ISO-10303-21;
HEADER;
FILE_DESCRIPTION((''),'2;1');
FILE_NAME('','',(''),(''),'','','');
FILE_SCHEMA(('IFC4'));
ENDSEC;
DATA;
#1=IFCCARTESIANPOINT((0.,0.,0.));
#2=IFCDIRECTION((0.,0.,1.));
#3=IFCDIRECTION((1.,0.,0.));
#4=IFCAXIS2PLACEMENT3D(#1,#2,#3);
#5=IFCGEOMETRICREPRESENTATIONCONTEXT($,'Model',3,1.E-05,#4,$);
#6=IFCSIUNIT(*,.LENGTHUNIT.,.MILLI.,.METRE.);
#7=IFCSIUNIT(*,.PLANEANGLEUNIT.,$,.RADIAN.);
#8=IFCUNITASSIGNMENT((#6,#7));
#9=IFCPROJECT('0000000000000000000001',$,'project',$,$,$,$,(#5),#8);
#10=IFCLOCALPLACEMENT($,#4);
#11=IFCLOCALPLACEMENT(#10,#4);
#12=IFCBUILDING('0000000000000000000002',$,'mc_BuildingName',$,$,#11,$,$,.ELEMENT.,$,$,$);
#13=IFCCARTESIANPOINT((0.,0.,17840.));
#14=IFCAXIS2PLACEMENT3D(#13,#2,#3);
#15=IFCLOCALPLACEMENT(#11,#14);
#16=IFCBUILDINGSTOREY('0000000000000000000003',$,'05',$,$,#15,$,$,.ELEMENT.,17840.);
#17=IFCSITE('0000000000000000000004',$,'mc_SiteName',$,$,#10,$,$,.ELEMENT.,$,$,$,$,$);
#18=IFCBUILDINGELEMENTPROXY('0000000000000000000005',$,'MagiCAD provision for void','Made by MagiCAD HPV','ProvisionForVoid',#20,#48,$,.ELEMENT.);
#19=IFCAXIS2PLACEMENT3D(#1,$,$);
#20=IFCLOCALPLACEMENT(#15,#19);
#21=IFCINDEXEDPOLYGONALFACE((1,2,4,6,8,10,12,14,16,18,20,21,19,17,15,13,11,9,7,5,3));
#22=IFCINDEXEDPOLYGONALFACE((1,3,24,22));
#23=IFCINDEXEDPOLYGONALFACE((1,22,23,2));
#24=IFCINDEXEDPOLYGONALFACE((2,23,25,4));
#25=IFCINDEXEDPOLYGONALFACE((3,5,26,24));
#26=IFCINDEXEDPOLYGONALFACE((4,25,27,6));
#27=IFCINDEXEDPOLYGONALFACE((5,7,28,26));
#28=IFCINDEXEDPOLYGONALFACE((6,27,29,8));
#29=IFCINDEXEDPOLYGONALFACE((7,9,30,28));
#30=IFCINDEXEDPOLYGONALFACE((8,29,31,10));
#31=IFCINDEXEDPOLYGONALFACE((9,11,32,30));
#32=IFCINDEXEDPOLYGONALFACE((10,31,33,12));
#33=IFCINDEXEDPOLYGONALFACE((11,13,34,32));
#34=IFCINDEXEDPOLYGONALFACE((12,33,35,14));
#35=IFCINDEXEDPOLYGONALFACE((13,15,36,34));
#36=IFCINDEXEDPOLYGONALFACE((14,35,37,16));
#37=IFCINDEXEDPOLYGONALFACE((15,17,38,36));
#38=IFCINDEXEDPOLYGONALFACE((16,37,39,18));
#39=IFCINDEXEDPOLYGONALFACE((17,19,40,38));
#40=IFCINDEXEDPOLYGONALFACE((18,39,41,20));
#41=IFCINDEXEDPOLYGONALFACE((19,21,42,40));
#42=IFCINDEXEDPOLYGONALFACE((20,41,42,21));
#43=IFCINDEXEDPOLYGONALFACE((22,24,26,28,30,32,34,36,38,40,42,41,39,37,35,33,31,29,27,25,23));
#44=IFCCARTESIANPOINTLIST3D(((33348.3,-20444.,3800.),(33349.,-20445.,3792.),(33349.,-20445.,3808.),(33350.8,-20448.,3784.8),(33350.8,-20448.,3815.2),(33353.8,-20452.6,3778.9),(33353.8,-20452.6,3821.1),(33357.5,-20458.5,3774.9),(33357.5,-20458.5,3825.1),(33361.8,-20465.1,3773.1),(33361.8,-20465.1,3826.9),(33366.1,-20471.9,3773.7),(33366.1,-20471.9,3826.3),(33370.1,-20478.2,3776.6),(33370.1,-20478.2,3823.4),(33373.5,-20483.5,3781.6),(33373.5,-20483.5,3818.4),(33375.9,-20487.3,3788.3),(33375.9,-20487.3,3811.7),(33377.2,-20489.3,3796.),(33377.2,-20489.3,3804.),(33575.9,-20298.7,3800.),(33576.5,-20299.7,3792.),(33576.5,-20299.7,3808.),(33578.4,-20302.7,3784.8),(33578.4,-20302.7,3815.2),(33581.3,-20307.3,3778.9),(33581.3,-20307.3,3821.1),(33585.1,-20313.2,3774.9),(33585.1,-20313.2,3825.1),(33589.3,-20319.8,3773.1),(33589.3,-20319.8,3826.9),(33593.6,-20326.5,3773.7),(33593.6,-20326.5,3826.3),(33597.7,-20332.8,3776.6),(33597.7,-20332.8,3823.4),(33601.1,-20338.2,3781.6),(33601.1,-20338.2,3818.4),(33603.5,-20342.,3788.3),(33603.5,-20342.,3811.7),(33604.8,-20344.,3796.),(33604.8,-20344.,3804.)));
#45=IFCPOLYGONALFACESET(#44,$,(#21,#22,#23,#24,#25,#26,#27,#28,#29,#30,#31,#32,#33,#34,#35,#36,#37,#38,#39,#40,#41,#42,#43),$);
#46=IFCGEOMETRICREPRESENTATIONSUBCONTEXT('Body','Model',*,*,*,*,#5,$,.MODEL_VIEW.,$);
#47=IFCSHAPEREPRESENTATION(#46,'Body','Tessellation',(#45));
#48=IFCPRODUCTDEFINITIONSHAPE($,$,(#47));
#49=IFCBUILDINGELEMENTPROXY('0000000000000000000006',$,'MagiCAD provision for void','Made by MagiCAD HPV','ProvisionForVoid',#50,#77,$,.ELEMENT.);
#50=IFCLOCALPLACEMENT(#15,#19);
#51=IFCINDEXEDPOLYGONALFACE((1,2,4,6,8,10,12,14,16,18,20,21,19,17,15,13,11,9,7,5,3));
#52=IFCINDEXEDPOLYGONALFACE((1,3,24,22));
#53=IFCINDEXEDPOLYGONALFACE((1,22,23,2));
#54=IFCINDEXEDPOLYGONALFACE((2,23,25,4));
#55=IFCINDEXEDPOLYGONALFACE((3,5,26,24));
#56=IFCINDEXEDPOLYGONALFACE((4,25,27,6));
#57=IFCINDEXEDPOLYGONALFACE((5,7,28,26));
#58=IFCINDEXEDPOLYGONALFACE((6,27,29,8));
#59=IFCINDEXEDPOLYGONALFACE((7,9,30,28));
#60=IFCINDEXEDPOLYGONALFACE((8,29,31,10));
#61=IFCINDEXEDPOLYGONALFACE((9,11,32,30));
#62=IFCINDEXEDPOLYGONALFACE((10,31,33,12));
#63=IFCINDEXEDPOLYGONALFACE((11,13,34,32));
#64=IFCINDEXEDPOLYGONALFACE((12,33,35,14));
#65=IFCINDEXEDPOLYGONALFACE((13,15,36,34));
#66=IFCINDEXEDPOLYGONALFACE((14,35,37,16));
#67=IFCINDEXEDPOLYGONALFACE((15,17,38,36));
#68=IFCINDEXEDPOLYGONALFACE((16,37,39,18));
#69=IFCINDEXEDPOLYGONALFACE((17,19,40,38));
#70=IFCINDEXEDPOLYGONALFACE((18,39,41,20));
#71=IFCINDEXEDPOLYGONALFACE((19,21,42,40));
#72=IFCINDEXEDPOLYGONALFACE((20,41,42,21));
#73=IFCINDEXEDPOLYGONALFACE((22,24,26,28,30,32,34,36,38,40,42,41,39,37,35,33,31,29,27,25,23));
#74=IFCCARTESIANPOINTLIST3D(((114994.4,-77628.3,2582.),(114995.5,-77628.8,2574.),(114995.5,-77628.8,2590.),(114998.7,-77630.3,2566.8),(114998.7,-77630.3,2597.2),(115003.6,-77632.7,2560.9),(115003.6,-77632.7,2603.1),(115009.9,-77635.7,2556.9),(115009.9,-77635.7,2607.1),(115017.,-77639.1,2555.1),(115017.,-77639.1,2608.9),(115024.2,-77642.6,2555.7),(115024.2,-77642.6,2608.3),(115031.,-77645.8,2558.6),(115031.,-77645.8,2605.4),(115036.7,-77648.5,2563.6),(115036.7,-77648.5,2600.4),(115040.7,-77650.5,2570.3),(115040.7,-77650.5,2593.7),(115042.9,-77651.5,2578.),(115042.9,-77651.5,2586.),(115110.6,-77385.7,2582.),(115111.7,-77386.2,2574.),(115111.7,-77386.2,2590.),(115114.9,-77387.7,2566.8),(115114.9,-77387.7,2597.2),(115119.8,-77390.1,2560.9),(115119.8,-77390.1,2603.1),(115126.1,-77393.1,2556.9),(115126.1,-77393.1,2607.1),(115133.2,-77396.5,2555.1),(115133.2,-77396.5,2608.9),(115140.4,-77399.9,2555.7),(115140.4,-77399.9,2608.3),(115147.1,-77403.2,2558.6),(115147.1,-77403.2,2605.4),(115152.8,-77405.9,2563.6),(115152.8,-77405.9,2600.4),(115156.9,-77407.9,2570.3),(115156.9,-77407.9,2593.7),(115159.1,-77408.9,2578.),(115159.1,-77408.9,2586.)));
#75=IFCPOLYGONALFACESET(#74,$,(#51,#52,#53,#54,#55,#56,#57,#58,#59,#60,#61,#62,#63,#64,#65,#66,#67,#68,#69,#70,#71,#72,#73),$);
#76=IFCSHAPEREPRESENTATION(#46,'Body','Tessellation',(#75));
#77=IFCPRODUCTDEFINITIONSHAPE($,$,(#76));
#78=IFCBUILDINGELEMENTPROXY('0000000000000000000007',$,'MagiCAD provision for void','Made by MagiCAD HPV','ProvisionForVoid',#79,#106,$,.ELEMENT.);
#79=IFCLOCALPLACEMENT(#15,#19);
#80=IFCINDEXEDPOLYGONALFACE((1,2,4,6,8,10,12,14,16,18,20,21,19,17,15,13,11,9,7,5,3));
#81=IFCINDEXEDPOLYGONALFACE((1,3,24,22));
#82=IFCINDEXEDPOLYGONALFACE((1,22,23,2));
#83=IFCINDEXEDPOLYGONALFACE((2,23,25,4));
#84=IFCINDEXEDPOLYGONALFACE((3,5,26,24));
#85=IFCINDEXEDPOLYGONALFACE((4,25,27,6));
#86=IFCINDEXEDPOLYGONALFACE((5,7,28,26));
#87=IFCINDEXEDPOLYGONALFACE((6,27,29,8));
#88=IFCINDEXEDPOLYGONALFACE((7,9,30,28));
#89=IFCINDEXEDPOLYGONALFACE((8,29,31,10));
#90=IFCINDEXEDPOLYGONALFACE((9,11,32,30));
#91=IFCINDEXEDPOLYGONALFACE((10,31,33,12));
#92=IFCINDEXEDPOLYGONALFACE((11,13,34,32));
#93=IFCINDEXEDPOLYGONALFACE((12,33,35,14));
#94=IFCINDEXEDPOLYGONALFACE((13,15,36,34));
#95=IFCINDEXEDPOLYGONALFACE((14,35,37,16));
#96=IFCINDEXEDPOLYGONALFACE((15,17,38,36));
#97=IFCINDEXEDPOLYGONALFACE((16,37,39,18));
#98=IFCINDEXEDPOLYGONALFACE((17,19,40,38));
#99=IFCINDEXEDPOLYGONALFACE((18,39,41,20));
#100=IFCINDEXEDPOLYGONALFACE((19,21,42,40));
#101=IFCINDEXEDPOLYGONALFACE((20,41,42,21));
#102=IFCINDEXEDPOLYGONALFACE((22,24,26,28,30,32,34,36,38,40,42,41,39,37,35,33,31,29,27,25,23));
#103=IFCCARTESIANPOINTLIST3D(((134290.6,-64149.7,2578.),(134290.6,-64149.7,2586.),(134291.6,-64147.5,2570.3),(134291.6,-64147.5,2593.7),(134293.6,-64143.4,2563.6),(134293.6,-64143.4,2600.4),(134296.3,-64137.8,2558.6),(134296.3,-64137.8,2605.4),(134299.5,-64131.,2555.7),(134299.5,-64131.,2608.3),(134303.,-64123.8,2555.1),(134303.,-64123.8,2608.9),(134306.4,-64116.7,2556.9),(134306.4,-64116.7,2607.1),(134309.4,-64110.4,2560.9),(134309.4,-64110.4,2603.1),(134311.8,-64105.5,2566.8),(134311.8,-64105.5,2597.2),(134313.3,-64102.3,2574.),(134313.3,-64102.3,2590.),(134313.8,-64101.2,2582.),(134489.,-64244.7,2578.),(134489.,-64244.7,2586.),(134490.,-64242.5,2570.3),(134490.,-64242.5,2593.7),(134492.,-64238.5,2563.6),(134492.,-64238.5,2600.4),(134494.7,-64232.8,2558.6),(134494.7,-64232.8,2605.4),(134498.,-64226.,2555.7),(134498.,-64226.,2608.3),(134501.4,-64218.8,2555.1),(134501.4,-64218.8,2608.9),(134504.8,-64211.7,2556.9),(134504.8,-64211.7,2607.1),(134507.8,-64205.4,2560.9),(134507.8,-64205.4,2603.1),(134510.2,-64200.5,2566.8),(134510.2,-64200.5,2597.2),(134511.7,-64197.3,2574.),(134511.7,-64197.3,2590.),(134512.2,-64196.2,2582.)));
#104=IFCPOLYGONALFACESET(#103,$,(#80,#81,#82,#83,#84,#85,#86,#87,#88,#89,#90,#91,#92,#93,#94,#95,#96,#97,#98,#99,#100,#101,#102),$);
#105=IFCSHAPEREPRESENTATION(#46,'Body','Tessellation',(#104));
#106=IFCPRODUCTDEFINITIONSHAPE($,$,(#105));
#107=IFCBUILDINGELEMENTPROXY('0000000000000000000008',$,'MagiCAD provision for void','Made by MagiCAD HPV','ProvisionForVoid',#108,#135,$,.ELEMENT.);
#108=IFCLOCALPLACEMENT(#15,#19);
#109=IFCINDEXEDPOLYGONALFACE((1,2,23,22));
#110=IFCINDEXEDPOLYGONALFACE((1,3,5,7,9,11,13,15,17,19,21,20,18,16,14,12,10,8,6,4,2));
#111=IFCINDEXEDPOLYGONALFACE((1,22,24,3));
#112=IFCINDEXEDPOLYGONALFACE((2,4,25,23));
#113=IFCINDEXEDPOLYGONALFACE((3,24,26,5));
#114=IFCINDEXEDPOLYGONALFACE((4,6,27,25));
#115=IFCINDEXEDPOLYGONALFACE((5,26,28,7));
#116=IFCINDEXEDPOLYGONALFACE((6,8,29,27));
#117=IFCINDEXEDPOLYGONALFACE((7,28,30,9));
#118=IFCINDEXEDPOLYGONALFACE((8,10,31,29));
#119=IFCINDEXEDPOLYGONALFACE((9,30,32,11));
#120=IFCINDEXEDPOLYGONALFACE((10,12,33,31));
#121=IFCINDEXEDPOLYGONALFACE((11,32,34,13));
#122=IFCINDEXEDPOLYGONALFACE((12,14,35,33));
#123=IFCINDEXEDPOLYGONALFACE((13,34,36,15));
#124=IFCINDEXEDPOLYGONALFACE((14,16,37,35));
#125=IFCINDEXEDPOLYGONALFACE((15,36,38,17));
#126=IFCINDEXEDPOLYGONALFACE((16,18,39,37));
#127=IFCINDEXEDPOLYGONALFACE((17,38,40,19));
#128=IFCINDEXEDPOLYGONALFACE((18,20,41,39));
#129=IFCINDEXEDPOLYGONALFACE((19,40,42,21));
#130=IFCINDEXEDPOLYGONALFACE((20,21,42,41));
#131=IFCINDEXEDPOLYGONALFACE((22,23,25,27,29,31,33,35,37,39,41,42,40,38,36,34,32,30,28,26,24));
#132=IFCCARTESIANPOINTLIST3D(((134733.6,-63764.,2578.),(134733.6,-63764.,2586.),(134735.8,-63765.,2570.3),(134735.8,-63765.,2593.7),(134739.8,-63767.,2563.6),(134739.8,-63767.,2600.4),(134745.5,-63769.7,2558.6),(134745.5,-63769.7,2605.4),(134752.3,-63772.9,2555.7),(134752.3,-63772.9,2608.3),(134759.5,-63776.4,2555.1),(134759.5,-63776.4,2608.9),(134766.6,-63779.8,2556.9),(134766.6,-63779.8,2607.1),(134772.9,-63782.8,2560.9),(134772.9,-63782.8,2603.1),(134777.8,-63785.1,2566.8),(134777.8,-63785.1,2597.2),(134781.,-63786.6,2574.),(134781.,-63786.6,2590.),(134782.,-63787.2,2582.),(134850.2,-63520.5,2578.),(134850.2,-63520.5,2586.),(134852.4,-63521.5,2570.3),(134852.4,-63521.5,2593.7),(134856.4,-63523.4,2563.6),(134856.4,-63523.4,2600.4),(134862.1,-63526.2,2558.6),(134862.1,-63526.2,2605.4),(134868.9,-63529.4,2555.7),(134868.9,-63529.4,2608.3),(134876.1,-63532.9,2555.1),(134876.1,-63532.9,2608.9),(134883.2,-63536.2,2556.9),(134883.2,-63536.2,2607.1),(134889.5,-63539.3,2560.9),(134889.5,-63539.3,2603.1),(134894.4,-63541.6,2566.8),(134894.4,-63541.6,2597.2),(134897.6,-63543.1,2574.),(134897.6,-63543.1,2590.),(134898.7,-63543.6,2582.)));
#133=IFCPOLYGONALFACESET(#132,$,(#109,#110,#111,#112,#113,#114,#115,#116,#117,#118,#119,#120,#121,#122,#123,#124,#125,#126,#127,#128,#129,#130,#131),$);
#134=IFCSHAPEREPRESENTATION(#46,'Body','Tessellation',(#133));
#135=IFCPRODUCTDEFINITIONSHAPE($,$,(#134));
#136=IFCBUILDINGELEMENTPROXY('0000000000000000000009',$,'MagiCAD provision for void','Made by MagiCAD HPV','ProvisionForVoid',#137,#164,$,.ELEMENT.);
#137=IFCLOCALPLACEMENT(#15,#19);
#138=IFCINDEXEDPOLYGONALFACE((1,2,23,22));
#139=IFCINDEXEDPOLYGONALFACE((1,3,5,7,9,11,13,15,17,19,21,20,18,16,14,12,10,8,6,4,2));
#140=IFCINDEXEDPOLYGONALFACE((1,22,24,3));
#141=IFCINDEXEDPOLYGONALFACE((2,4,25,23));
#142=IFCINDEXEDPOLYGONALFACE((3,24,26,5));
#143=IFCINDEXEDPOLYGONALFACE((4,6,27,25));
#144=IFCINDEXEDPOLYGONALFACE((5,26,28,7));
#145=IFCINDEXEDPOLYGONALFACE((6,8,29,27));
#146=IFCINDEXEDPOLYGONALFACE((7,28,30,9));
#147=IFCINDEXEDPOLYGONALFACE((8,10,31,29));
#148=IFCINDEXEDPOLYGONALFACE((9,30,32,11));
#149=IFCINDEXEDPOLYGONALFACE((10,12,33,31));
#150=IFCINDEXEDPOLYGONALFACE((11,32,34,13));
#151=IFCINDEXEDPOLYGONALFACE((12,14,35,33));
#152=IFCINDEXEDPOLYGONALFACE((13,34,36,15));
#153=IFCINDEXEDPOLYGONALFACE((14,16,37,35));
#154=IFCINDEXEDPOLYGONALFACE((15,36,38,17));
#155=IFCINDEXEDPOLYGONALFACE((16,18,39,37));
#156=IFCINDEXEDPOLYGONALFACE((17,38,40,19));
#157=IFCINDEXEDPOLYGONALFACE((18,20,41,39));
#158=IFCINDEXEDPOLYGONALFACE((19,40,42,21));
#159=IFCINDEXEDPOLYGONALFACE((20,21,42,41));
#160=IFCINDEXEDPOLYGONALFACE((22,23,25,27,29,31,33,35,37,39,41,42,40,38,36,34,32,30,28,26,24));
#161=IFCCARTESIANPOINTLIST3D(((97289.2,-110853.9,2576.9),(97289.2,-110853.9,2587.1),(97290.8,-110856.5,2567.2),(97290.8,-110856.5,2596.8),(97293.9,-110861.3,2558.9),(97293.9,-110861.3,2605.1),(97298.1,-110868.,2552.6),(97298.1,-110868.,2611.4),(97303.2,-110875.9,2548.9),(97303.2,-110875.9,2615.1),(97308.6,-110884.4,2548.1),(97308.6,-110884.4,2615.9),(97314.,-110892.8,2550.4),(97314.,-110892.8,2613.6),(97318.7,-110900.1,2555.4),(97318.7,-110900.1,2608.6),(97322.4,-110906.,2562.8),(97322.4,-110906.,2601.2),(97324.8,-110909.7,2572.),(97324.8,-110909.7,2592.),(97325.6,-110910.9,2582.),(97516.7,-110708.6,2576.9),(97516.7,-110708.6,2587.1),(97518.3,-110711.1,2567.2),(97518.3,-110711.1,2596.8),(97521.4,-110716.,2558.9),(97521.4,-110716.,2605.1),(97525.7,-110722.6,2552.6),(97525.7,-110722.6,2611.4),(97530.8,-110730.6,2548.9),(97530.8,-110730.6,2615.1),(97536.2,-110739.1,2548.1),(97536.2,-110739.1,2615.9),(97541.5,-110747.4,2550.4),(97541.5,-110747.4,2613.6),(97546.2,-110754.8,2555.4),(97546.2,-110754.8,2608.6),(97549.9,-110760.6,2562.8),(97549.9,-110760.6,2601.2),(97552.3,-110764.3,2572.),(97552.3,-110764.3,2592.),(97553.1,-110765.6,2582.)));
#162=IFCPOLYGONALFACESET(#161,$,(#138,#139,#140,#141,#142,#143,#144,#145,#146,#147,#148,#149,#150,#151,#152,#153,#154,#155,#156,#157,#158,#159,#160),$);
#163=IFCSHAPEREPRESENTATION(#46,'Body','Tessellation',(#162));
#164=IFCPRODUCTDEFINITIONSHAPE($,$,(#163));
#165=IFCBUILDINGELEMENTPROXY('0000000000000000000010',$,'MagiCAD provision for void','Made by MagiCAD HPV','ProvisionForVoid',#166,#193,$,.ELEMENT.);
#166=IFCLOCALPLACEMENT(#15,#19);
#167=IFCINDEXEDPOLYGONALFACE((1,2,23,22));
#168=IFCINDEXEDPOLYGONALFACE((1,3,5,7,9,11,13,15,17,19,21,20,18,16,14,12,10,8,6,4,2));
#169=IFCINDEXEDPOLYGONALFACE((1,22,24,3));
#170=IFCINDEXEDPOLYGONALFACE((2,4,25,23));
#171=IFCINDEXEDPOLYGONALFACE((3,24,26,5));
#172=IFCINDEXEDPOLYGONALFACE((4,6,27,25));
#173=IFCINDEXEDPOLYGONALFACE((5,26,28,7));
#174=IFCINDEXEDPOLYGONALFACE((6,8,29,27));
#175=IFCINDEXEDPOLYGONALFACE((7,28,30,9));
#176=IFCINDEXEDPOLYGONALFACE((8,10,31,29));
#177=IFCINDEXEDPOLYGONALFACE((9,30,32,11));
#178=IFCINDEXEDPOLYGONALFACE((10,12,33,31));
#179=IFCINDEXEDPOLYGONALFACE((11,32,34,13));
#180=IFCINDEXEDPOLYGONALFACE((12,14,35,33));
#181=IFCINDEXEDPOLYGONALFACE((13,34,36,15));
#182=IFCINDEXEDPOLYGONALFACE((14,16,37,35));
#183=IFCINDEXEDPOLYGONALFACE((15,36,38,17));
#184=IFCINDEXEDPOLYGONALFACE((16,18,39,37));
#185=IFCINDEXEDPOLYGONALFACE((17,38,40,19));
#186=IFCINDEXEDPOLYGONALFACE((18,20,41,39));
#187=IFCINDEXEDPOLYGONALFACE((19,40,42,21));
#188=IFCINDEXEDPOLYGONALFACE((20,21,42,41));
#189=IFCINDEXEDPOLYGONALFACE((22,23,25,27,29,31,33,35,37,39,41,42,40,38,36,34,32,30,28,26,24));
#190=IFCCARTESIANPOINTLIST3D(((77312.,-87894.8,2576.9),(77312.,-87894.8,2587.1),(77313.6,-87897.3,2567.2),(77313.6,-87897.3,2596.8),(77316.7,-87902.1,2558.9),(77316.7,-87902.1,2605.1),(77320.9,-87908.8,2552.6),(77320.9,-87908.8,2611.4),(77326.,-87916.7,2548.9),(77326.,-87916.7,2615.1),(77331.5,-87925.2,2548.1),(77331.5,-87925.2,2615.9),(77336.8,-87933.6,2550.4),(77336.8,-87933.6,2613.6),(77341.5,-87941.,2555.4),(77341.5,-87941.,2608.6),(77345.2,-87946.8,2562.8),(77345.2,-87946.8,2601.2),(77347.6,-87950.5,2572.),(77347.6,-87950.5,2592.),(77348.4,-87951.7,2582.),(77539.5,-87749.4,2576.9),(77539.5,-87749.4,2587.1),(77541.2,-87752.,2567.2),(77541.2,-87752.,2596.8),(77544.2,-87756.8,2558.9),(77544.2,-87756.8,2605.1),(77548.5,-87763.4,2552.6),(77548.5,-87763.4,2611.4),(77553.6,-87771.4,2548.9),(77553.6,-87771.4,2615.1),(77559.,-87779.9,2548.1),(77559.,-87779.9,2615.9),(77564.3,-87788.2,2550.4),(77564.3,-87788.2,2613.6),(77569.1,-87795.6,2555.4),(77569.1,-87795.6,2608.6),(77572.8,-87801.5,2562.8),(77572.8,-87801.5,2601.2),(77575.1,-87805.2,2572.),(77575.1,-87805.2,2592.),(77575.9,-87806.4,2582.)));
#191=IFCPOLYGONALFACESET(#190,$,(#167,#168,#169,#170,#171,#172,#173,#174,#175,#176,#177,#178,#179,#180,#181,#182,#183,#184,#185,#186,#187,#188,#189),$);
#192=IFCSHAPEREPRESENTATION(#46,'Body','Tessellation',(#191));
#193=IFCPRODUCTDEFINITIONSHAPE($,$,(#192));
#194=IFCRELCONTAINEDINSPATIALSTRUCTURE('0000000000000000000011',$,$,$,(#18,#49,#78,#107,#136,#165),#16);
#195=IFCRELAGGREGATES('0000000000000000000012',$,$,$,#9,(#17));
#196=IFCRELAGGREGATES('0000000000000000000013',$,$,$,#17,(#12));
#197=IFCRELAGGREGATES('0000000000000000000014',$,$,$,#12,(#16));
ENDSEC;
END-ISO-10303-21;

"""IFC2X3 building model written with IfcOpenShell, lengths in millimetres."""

from ifc_helpers import new_model, si_unit, frame, origin_with_axes, origin_2d_with_axis, place, context, subcontext, project, spatial, circle, extrude, source, transform, mapped, element, save


model = new_model("IFC2X3")

# Units and contexts
model_context = context("Model", 3, precision=1e-05, world=origin_with_axes())
body_context = subcontext(model_context, "Body", "Model", "MODEL_VIEW")
ifc_project = project(units=[si_unit("LENGTHUNIT", "METRE", prefix="MILLI"), si_unit("PLANEANGLEUNIT", "RADIAN")], contexts=[model_context])

# Site, building, storey
site_placement = place(None, origin_with_axes())
site = spatial("IfcSite", under=ifc_project, at=site_placement, Name="mc_SiteName", CompositionType="ELEMENT")
building_placement = place(site_placement, origin_with_axes())
building = spatial("IfcBuilding", under=site, at=building_placement, Name="mc_BuildingName", CompositionType="ELEMENT")
storey_placement = place(building_placement, frame((0.0, 0.0, 17840.0), z_axis=(0.0, 0.0, 1.0), x_axis=(1.0, 0.0, 0.0)))
storey = spatial("IfcBuildingStorey", under=building, at=storey_placement, Name="05", CompositionType="ELEMENT", Elevation=17840.0)

# Building element proxies
shared_shape_1 = source(origin_with_axes(), body_context, "Body", "SweptSolid", [
    extrude(circle(Radius=27.0, at=origin_2d_with_axis()), frame((0.0, 0.0, 0.0), z_axis=(1.0, 0.0, 0.0), x_axis=(0.0, 1.0, 0.0)), (0.0, 0.0, 1.0), 270.0),
])
proxy_1_placement = place(storey_placement, frame((33362.8, -20466.8, 3800.0), z_axis=(0.0, 0.0, 1.0), x_axis=(0.842809, 0.538213, 0.0)))
element("IfcBuildingElementProxy", 1, at=proxy_1_placement, inside=storey, Name="MagiCAD provision for void", Description="Made by MagiCAD HPV", ObjectType="ProvisionForVoid", CompositionType="ELEMENT", context=body_context, shape_type="MappedRepresentation", body=[
    mapped(shared_shape_1, transform((0.0, 0.0, 0.0), scale=1.0)),
])
shared_shape_2 = source(origin_with_axes(), body_context, "Body", "SweptSolid", [
    extrude(circle(Radius=27.0, at=origin_2d_with_axis()), frame((0.0, 0.0, 0.0), z_axis=(1.0, 0.0, 0.0), x_axis=(0.0, 1.0, 0.0)), (0.0, 0.0, 1.0), 269.0),
])
proxy_2_placement = place(storey_placement, frame((115018.8, -77640.0, 2582.0), z_axis=(0.0, 0.0, 1.0), x_axis=(0.431859, 0.901941, 0.0)))
element("IfcBuildingElementProxy", 2, at=proxy_2_placement, inside=storey, Name="MagiCAD provision for void", Description="Made by MagiCAD HPV", ObjectType="ProvisionForVoid", CompositionType="ELEMENT", context=body_context, shape_type="MappedRepresentation", body=[
    mapped(shared_shape_2, transform((0.0, 0.0, 0.0), scale=1.0)),
])
shared_shape_3 = source(origin_with_axes(), body_context, "Body", "SweptSolid", [
    extrude(circle(Radius=27.0, at=origin_2d_with_axis()), frame((0.0, 0.0, 0.0), z_axis=(1.0, 0.0, 0.0), x_axis=(0.0, 1.0, 0.0)), (0.0, 0.0, 1.0), 220.0),
])
proxy_3_placement = place(storey_placement, frame((134302.1, -64125.6, 2582.0), z_axis=(0.0, 0.0, 1.0), x_axis=(0.901941, -0.431859, 0.0)))
element("IfcBuildingElementProxy", 3, at=proxy_3_placement, inside=storey, Name="MagiCAD provision for void", Description="Made by MagiCAD HPV", ObjectType="ProvisionForVoid", CompositionType="ELEMENT", context=body_context, shape_type="MappedRepresentation", body=[
    mapped(shared_shape_3, transform((0.0, 0.0, 0.0), scale=1.0)),
])
shared_shape_4 = source(origin_with_axes(), body_context, "Body", "SweptSolid", [
    extrude(circle(Radius=27.0, at=origin_2d_with_axis()), frame((0.0, 0.0, 0.0), z_axis=(1.0, 0.0, 0.0), x_axis=(0.0, 1.0, 0.0)), (0.0, 0.0, 1.0), 270.0),
])
proxy_4_placement = place(storey_placement, frame((134874.3, -63532.0, 2582.0), z_axis=(0.0, 0.0, 1.0), x_axis=(-0.431882, -0.90193, 0.0)))
element("IfcBuildingElementProxy", 4, at=proxy_4_placement, inside=storey, Name="MagiCAD provision for void", Description="Made by MagiCAD HPV", ObjectType="ProvisionForVoid", CompositionType="ELEMENT", context=body_context, shape_type="MappedRepresentation", body=[
    mapped(shared_shape_4, transform((0.0, 0.0, 0.0), scale=1.0)),
])
shared_shape_5 = source(origin_with_axes(), body_context, "Body", "SweptSolid", [
    extrude(circle(Radius=34.0, at=origin_2d_with_axis()), frame((0.0, 0.0, 0.0), z_axis=(1.0, 0.0, 0.0), x_axis=(0.0, 1.0, 0.0)), (0.0, 0.0, 1.0), 270.0),
])
proxy_5_placement = place(storey_placement, frame((97534.8, -110737.0, 2582.0), z_axis=(0.0, 0.0, 1.0), x_axis=(-0.842809, -0.538213, 0.0)))
element("IfcBuildingElementProxy", 5, at=proxy_5_placement, inside=storey, Name="MagiCAD provision for void", Description="Made by MagiCAD HPV", ObjectType="ProvisionForVoid", CompositionType="ELEMENT", context=body_context, shape_type="MappedRepresentation", body=[
    mapped(shared_shape_5, transform((0.0, 0.0, 0.0), scale=1.0)),
])
shared_shape_6 = source(origin_with_axes(), body_context, "Body", "SweptSolid", [
    extrude(circle(Radius=34.0, at=origin_2d_with_axis()), frame((0.0, 0.0, 0.0), z_axis=(1.0, 0.0, 0.0), x_axis=(0.0, 1.0, 0.0)), (0.0, 0.0, 1.0), 270.0),
])
proxy_6_placement = place(storey_placement, frame((77557.6, -87777.8, 2582.0), z_axis=(0.0, 0.0, 1.0), x_axis=(-0.842809, -0.538213, 0.0)))
element("IfcBuildingElementProxy", 6, at=proxy_6_placement, inside=storey, Name="MagiCAD provision for void", Description="Made by MagiCAD HPV", ObjectType="ProvisionForVoid", CompositionType="ELEMENT", context=body_context, shape_type="MappedRepresentation", body=[
    mapped(shared_shape_6, transform((0.0, 0.0, 0.0), scale=1.0)),
])

save(model, "model.ifc")
